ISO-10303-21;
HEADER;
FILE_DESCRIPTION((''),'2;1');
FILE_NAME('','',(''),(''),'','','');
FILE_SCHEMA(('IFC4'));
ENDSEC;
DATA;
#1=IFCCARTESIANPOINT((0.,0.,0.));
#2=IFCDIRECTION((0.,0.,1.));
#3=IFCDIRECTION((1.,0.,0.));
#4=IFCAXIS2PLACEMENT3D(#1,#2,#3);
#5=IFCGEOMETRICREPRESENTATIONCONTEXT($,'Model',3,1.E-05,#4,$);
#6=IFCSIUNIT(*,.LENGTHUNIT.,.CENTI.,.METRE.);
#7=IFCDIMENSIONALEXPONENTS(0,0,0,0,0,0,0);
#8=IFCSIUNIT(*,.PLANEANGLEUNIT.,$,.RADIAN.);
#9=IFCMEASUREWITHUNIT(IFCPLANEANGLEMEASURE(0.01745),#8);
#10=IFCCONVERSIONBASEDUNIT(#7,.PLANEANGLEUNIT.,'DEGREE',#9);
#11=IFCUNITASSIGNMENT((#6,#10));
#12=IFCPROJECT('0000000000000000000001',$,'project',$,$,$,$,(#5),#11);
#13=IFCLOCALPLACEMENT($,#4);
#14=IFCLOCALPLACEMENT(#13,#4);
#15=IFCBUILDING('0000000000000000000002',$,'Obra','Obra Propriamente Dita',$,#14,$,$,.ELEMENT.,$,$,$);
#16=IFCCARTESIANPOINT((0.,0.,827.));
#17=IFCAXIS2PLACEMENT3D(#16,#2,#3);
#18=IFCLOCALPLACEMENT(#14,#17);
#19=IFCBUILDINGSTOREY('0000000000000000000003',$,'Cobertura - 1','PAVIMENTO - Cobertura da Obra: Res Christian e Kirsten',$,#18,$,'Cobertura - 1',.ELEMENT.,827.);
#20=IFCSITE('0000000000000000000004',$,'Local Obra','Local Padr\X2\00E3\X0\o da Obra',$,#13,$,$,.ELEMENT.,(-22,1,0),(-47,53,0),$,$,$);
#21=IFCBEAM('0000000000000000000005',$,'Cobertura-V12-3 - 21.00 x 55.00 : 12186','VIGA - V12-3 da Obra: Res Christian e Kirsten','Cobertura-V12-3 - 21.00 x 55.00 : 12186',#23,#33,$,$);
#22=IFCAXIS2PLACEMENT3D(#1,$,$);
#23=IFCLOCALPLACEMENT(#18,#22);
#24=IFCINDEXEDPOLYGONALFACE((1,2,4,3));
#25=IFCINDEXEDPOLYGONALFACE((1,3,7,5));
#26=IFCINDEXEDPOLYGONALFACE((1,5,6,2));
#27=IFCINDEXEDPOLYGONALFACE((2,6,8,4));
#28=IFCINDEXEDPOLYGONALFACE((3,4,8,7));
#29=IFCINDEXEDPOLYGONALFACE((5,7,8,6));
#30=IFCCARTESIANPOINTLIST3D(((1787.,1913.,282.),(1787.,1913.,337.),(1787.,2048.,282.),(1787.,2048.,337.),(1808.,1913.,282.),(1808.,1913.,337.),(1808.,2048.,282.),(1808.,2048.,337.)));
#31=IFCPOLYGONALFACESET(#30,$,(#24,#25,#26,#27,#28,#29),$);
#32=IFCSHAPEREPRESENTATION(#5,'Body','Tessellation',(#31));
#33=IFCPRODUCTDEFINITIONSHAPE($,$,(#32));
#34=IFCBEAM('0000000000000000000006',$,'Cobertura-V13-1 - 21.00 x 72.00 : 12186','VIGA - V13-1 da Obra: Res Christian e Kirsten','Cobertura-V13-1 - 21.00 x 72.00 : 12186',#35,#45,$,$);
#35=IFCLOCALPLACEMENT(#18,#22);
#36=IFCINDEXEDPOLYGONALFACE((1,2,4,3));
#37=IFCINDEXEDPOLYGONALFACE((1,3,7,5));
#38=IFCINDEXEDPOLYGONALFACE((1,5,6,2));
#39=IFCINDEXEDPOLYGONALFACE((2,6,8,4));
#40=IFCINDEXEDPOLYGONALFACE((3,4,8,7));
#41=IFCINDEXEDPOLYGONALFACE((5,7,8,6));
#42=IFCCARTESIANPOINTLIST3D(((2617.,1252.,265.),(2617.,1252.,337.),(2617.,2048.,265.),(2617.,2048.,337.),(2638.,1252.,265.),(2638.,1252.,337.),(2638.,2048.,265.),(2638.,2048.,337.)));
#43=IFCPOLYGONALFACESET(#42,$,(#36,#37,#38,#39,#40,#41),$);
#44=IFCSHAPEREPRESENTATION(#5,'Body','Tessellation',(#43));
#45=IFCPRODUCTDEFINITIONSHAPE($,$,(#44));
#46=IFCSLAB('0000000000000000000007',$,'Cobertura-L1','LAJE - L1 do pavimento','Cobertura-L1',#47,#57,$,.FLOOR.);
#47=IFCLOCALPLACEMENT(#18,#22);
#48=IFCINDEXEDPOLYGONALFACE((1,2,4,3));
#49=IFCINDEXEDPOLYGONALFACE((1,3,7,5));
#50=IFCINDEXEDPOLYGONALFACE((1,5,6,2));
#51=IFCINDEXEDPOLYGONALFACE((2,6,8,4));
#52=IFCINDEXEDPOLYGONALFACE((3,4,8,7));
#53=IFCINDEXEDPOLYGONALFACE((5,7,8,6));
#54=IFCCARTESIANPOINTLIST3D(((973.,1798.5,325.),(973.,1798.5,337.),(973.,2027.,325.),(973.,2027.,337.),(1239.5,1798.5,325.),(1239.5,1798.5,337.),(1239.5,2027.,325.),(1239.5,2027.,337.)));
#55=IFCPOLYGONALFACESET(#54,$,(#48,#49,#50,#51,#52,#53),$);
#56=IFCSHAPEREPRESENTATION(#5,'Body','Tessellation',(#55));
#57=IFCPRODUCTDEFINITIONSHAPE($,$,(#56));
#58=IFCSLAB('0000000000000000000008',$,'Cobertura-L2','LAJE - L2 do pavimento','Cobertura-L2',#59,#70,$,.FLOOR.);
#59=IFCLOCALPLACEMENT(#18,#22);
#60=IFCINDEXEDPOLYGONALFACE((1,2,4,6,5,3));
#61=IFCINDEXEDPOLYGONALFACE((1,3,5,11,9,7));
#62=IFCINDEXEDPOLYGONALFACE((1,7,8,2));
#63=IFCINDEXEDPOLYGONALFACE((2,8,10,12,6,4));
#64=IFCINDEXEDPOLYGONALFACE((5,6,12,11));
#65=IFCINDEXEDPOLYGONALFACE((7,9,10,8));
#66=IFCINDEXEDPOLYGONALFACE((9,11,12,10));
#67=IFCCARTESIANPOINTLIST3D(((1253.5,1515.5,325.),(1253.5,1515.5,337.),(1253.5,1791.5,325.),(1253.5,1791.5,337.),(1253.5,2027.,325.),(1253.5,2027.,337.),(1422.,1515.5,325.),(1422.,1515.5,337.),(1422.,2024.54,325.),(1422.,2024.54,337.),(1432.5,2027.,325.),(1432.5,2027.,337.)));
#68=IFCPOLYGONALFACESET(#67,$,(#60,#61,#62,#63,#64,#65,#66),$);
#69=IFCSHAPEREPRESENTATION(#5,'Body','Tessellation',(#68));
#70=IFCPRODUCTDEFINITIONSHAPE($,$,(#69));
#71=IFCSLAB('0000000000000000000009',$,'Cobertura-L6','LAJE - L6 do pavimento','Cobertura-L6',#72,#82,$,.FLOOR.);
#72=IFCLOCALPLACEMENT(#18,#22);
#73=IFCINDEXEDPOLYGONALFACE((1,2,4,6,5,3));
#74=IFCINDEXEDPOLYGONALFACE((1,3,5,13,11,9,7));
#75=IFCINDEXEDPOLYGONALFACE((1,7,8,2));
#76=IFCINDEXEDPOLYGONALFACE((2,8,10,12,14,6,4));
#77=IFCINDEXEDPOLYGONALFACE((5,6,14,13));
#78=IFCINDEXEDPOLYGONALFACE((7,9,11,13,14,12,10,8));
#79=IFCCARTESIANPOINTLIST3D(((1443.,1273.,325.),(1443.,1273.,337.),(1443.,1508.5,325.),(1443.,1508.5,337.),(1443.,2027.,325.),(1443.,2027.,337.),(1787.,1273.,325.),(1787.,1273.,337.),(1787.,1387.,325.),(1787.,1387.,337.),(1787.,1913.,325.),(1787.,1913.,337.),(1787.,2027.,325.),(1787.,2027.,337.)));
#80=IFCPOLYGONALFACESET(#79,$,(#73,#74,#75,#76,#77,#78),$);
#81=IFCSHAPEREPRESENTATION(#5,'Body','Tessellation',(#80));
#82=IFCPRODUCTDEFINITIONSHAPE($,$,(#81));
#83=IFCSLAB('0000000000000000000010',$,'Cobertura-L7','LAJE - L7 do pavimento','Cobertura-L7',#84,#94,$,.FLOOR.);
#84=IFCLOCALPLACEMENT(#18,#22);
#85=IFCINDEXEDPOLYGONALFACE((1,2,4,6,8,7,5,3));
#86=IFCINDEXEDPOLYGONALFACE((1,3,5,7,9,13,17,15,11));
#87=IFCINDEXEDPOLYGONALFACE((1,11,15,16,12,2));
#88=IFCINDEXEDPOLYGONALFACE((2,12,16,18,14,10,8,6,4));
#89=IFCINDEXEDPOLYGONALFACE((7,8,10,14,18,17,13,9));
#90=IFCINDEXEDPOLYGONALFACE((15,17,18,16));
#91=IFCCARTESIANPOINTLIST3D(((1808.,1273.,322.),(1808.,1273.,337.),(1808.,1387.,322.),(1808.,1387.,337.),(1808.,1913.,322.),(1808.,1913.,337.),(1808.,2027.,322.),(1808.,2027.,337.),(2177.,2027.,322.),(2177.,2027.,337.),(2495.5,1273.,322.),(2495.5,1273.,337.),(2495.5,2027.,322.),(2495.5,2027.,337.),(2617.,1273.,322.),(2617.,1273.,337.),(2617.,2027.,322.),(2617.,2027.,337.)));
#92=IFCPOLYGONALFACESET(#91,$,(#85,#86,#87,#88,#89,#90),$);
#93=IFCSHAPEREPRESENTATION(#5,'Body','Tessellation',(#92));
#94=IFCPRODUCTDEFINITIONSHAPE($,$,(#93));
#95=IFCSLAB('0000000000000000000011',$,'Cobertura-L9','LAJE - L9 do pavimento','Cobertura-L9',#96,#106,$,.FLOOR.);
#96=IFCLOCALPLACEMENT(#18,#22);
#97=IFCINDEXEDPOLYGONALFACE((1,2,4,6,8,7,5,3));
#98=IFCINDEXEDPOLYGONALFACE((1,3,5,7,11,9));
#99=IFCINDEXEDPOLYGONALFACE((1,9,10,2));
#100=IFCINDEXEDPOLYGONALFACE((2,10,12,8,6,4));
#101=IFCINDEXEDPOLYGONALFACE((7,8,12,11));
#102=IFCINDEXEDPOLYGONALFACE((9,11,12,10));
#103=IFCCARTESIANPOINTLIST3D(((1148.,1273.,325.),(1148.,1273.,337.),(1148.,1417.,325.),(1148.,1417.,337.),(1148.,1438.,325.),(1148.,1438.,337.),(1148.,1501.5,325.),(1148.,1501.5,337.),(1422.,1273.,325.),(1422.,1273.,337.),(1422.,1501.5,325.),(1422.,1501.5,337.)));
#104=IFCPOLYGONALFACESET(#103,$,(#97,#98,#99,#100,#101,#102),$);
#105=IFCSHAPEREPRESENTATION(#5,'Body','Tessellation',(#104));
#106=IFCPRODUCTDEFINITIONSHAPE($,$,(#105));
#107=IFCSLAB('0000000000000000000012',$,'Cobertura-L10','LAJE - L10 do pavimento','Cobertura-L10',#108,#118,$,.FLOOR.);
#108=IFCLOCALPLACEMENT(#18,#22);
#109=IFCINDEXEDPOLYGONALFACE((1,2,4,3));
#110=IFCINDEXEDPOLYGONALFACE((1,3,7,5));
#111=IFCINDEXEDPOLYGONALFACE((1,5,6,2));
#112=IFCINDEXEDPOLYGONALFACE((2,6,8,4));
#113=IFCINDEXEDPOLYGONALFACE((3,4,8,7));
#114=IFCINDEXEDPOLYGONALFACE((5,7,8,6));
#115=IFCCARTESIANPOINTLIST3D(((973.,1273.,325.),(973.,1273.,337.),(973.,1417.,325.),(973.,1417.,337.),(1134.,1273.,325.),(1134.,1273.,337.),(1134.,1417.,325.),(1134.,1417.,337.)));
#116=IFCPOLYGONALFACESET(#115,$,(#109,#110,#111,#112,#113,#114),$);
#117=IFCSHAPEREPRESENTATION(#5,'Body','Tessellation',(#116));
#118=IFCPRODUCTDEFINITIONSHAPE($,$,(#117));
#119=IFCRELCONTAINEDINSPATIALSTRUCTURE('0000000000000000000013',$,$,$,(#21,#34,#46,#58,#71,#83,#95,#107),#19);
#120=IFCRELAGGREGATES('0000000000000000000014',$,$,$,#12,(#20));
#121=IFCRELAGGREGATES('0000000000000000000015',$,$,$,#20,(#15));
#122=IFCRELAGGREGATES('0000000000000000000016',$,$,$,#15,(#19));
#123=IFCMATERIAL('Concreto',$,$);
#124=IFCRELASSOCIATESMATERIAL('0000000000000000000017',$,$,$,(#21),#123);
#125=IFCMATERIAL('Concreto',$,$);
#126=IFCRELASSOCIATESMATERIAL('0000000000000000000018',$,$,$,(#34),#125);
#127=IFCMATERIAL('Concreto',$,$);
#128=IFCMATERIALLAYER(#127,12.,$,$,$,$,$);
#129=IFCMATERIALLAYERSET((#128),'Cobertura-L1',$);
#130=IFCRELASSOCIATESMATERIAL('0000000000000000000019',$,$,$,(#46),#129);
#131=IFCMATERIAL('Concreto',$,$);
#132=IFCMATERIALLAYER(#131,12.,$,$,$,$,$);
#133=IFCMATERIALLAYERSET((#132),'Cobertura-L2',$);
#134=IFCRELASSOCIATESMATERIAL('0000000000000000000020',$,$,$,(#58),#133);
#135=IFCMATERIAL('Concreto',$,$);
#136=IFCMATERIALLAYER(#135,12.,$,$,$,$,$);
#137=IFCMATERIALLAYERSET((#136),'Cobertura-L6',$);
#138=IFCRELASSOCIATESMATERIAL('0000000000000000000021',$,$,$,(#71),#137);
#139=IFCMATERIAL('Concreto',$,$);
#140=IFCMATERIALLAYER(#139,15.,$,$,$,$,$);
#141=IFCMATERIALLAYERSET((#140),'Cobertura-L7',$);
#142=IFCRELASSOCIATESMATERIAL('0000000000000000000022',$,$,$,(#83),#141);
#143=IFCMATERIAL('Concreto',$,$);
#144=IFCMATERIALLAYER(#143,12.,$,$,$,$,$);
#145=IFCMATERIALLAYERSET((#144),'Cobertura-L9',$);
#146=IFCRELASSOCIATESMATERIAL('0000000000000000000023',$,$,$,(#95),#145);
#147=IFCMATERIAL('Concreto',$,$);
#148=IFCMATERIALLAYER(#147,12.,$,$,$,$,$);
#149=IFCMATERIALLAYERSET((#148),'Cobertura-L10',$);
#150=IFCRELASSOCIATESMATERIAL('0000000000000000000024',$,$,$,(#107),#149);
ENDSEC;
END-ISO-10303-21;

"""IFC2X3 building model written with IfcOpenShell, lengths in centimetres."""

from ifc_helpers import new_model, entity, si_unit, converted_unit, frame, origin_with_axes, place, context, project, spatial, polyline, outline, extrude, material, layer, layer_set, layer_usage, element, save


model = new_model("IFC2X3")

# Units and contexts
model_context = context("Model", 3, precision=1e-05, world=origin_with_axes())
ifc_project = project(units=[si_unit("LENGTHUNIT", "METRE", prefix="CENTI"), converted_unit("PLANEANGLEUNIT", "DEGREE", entity("IfcPlaneAngleMeasure", 0.01745), si_unit("PLANEANGLEUNIT", "RADIAN"), dimensions=[0, 0, 0, 0, 0, 0, 0])], contexts=[model_context])

# Site, building, storey
site_placement = place(None, origin_with_axes())
site = spatial("IfcSite", under=ifc_project, at=site_placement, Name="Local Obra", Description="Local Padrão da Obra", CompositionType="ELEMENT", RefLatitude=(-22, 1, 0), RefLongitude=(-47, 53, 0))
building_placement = place(site_placement, origin_with_axes())
building = spatial("IfcBuilding", under=site, at=building_placement, Name="Obra", Description="Obra Propriamente Dita", CompositionType="ELEMENT")
storey_placement = place(building_placement, frame((0.0, 0.0, 827.0), z_axis=(0.0, 0.0, 1.0), x_axis=(1.0, 0.0, 0.0)))
storey = spatial("IfcBuildingStorey", under=building, at=storey_placement, Name="Cobertura - 1", Description="PAVIMENTO - Cobertura da Obra: Res Christian e Kirsten", LongName="Cobertura - 1", CompositionType="ELEMENT", Elevation=827.0)

# Beams
ifc_material_1 = material(Name="Concreto")
beam_1_placement = place(storey_placement, frame((1808.0, 1913.0, 337.0), z_axis=(0.0, 1.0, 0.0), x_axis=(1.0, 0.0, 0.0)))
element("IfcBeam", 1, at=beam_1_placement, inside=storey, material=ifc_material_1, Name="Cobertura-V12-3 - 21.00 x 55.00 : 12186", Description="VIGA - V12-3 da Obra: Res Christian e Kirsten", ObjectType="Cobertura-V12-3 - 21.00 x 55.00 : 12186", context=model_context, shape_type="SweptSolid", body=[
    extrude(outline(polyline([(-21.0, 0.0), (0.0, 0.0), (0.0, 55.0), (-21.0, 55.0), (-21.0, 0.0)])), origin_with_axes(), (0.0, 0.0, 1.0), 135.0),
])
ifc_material_2 = material(Name="Concreto")
beam_2_placement = place(storey_placement, frame((2638.0, 1252.0, 337.0), z_axis=(0.0, 1.0, 0.0), x_axis=(1.0, 0.0, 0.0)))
element("IfcBeam", 2, at=beam_2_placement, inside=storey, material=ifc_material_2, Name="Cobertura-V13-1 - 21.00 x 72.00 : 12186", Description="VIGA - V13-1 da Obra: Res Christian e Kirsten", ObjectType="Cobertura-V13-1 - 21.00 x 72.00 : 12186", context=model_context, shape_type="SweptSolid", body=[
    extrude(outline(polyline([(-21.0, 0.0), (0.0, 0.0), (0.0, 72.0), (-21.0, 72.0), (-21.0, 0.0)])), origin_with_axes(), (0.0, 0.0, 1.0), 796.0),
])

# Slabs
ifc_material_3 = material(Name="Concreto")
ifc_layer_1 = layer(ifc_material_3, 12.0)
ifc_layer_set_1 = layer_set([ifc_layer_1], Name="Cobertura-L1")
ifc_layer_usage_1 = layer_usage(ifc_layer_set_1, "AXIS3", "POSITIVE", 0.0)
slab_1_placement = place(storey_placement, frame((1239.5, 1798.5, 325.0), z_axis=(0.0, 0.0, 1.0), x_axis=(1.0, 0.0, 0.0)))
element("IfcSlab", 3, at=slab_1_placement, inside=storey, material=ifc_layer_usage_1, Name="Cobertura-L1", Description="LAJE - L1 do pavimento", ObjectType="Cobertura-L1", PredefinedType="FLOOR", context=model_context, shape_type="SweptSolid", body=[
    extrude(outline(polyline([(0.0, 228.5), (-266.5, 228.5), (-266.5, 0.0), (0.0, 0.0), (0.0, 228.5)])), origin_with_axes(), (0.0, 0.0, 1.0), 12.0),
])
ifc_material_4 = material(Name="Concreto")
ifc_layer_2 = layer(ifc_material_4, 12.0)
ifc_layer_set_2 = layer_set([ifc_layer_2], Name="Cobertura-L2")
ifc_layer_usage_2 = layer_usage(ifc_layer_set_2, "AXIS3", "POSITIVE", 0.0)
slab_2_placement = place(storey_placement, frame((1422.0, 2024.54, 325.0), z_axis=(0.0, 0.0, 1.0), x_axis=(1.0, 0.0, 0.0)))
element("IfcSlab", 4, at=slab_2_placement, inside=storey, material=ifc_layer_usage_2, Name="Cobertura-L2", Description="LAJE - L2 do pavimento", ObjectType="Cobertura-L2", PredefinedType="FLOOR", context=model_context, shape_type="SweptSolid", body=[
    extrude(outline(polyline([(10.5, 2.46), (-168.5, 2.46), (-168.5, -233.04), (-168.5, -509.04), (0.0, -509.04), (0.0, 0.0), (10.5, 2.46)])), origin_with_axes(), (0.0, 0.0, 1.0), 12.0),
])
ifc_material_5 = material(Name="Concreto")
ifc_layer_3 = layer(ifc_material_5, 12.0)
ifc_layer_set_3 = layer_set([ifc_layer_3], Name="Cobertura-L6")
ifc_layer_usage_3 = layer_usage(ifc_layer_set_3, "AXIS3", "POSITIVE", 0.0)
slab_3_placement = place(storey_placement, frame((1787.0, 1913.0, 325.0), z_axis=(0.0, 0.0, 1.0), x_axis=(1.0, 0.0, 0.0)))
element("IfcSlab", 5, at=slab_3_placement, inside=storey, material=ifc_layer_usage_3, Name="Cobertura-L6", Description="LAJE - L6 do pavimento", ObjectType="Cobertura-L6", PredefinedType="FLOOR", context=model_context, shape_type="SweptSolid", body=[
    extrude(outline(polyline([(0.0, 114.0), (-344.0, 114.0), (-344.0, -404.5), (-344.0, -640.0), (0.0, -640.0), (0.0, -526.0), (0.0, 0.0), (0.0, 114.0)])), origin_with_axes(), (0.0, 0.0, 1.0), 12.0),
])
ifc_material_6 = material(Name="Concreto")
ifc_layer_4 = layer(ifc_material_6, 15.0)
ifc_layer_set_4 = layer_set([ifc_layer_4], Name="Cobertura-L7")
ifc_layer_usage_4 = layer_usage(ifc_layer_set_4, "AXIS3", "POSITIVE", 0.0)
slab_4_placement = place(storey_placement, frame((1808.0, 2027.0, 322.0), z_axis=(0.0, 0.0, 1.0), x_axis=(1.0, 0.0, 0.0)))
element("IfcSlab", 6, at=slab_4_placement, inside=storey, material=ifc_layer_usage_4, Name="Cobertura-L7", Description="LAJE - L7 do pavimento", ObjectType="Cobertura-L7", PredefinedType="FLOOR", context=model_context, shape_type="SweptSolid", body=[
    extrude(outline(polyline([(0.0, -114.0), (0.0, -640.0), (0.0, -754.0), (687.5, -754.0), (809.0, -754.0), (809.0, 0.0), (687.5, 0.0), (369.0, 0.0), (0.0, 0.0), (0.0, -114.0)])), origin_with_axes(), (0.0, 0.0, 1.0), 15.0),
])
ifc_material_7 = material(Name="Concreto")
ifc_layer_5 = layer(ifc_material_7, 12.0)
ifc_layer_set_5 = layer_set([ifc_layer_5], Name="Cobertura-L9")
ifc_layer_usage_5 = layer_usage(ifc_layer_set_5, "AXIS3", "POSITIVE", 0.0)
slab_5_placement = place(storey_placement, frame((1422.0, 1273.0, 325.0), z_axis=(0.0, 0.0, 1.0), x_axis=(1.0, 0.0, 0.0)))
element("IfcSlab", 7, at=slab_5_placement, inside=storey, material=ifc_layer_usage_5, Name="Cobertura-L9", Description="LAJE - L9 do pavimento", ObjectType="Cobertura-L9", PredefinedType="FLOOR", context=model_context, shape_type="SweptSolid", body=[
    extrude(outline(polyline([(0.0, 228.5), (-274.0, 228.5), (-274.0, 165.0), (-274.0, 144.0), (-274.0, 0.0), (0.0, 0.0), (0.0, 228.5)])), origin_with_axes(), (0.0, 0.0, 1.0), 12.0),
])
ifc_material_8 = material(Name="Concreto")
ifc_layer_6 = layer(ifc_material_8, 12.0)
ifc_layer_set_6 = layer_set([ifc_layer_6], Name="Cobertura-L10")
ifc_layer_usage_6 = layer_usage(ifc_layer_set_6, "AXIS3", "POSITIVE", 0.0)
slab_6_placement = place(storey_placement, frame((1134.0, 1273.0, 325.0), z_axis=(0.0, 0.0, 1.0), x_axis=(1.0, 0.0, 0.0)))
element("IfcSlab", 8, at=slab_6_placement, inside=storey, material=ifc_layer_usage_6, Name="Cobertura-L10", Description="LAJE - L10 do pavimento", ObjectType="Cobertura-L10", PredefinedType="FLOOR", context=model_context, shape_type="SweptSolid", body=[
    extrude(outline(polyline([(0.0, 144.0), (-161.0, 144.0), (-161.0, 0.0), (0.0, 0.0), (0.0, 144.0)])), origin_with_axes(), (0.0, 0.0, 1.0), 12.0),
])

save(model, "model.ifc")
